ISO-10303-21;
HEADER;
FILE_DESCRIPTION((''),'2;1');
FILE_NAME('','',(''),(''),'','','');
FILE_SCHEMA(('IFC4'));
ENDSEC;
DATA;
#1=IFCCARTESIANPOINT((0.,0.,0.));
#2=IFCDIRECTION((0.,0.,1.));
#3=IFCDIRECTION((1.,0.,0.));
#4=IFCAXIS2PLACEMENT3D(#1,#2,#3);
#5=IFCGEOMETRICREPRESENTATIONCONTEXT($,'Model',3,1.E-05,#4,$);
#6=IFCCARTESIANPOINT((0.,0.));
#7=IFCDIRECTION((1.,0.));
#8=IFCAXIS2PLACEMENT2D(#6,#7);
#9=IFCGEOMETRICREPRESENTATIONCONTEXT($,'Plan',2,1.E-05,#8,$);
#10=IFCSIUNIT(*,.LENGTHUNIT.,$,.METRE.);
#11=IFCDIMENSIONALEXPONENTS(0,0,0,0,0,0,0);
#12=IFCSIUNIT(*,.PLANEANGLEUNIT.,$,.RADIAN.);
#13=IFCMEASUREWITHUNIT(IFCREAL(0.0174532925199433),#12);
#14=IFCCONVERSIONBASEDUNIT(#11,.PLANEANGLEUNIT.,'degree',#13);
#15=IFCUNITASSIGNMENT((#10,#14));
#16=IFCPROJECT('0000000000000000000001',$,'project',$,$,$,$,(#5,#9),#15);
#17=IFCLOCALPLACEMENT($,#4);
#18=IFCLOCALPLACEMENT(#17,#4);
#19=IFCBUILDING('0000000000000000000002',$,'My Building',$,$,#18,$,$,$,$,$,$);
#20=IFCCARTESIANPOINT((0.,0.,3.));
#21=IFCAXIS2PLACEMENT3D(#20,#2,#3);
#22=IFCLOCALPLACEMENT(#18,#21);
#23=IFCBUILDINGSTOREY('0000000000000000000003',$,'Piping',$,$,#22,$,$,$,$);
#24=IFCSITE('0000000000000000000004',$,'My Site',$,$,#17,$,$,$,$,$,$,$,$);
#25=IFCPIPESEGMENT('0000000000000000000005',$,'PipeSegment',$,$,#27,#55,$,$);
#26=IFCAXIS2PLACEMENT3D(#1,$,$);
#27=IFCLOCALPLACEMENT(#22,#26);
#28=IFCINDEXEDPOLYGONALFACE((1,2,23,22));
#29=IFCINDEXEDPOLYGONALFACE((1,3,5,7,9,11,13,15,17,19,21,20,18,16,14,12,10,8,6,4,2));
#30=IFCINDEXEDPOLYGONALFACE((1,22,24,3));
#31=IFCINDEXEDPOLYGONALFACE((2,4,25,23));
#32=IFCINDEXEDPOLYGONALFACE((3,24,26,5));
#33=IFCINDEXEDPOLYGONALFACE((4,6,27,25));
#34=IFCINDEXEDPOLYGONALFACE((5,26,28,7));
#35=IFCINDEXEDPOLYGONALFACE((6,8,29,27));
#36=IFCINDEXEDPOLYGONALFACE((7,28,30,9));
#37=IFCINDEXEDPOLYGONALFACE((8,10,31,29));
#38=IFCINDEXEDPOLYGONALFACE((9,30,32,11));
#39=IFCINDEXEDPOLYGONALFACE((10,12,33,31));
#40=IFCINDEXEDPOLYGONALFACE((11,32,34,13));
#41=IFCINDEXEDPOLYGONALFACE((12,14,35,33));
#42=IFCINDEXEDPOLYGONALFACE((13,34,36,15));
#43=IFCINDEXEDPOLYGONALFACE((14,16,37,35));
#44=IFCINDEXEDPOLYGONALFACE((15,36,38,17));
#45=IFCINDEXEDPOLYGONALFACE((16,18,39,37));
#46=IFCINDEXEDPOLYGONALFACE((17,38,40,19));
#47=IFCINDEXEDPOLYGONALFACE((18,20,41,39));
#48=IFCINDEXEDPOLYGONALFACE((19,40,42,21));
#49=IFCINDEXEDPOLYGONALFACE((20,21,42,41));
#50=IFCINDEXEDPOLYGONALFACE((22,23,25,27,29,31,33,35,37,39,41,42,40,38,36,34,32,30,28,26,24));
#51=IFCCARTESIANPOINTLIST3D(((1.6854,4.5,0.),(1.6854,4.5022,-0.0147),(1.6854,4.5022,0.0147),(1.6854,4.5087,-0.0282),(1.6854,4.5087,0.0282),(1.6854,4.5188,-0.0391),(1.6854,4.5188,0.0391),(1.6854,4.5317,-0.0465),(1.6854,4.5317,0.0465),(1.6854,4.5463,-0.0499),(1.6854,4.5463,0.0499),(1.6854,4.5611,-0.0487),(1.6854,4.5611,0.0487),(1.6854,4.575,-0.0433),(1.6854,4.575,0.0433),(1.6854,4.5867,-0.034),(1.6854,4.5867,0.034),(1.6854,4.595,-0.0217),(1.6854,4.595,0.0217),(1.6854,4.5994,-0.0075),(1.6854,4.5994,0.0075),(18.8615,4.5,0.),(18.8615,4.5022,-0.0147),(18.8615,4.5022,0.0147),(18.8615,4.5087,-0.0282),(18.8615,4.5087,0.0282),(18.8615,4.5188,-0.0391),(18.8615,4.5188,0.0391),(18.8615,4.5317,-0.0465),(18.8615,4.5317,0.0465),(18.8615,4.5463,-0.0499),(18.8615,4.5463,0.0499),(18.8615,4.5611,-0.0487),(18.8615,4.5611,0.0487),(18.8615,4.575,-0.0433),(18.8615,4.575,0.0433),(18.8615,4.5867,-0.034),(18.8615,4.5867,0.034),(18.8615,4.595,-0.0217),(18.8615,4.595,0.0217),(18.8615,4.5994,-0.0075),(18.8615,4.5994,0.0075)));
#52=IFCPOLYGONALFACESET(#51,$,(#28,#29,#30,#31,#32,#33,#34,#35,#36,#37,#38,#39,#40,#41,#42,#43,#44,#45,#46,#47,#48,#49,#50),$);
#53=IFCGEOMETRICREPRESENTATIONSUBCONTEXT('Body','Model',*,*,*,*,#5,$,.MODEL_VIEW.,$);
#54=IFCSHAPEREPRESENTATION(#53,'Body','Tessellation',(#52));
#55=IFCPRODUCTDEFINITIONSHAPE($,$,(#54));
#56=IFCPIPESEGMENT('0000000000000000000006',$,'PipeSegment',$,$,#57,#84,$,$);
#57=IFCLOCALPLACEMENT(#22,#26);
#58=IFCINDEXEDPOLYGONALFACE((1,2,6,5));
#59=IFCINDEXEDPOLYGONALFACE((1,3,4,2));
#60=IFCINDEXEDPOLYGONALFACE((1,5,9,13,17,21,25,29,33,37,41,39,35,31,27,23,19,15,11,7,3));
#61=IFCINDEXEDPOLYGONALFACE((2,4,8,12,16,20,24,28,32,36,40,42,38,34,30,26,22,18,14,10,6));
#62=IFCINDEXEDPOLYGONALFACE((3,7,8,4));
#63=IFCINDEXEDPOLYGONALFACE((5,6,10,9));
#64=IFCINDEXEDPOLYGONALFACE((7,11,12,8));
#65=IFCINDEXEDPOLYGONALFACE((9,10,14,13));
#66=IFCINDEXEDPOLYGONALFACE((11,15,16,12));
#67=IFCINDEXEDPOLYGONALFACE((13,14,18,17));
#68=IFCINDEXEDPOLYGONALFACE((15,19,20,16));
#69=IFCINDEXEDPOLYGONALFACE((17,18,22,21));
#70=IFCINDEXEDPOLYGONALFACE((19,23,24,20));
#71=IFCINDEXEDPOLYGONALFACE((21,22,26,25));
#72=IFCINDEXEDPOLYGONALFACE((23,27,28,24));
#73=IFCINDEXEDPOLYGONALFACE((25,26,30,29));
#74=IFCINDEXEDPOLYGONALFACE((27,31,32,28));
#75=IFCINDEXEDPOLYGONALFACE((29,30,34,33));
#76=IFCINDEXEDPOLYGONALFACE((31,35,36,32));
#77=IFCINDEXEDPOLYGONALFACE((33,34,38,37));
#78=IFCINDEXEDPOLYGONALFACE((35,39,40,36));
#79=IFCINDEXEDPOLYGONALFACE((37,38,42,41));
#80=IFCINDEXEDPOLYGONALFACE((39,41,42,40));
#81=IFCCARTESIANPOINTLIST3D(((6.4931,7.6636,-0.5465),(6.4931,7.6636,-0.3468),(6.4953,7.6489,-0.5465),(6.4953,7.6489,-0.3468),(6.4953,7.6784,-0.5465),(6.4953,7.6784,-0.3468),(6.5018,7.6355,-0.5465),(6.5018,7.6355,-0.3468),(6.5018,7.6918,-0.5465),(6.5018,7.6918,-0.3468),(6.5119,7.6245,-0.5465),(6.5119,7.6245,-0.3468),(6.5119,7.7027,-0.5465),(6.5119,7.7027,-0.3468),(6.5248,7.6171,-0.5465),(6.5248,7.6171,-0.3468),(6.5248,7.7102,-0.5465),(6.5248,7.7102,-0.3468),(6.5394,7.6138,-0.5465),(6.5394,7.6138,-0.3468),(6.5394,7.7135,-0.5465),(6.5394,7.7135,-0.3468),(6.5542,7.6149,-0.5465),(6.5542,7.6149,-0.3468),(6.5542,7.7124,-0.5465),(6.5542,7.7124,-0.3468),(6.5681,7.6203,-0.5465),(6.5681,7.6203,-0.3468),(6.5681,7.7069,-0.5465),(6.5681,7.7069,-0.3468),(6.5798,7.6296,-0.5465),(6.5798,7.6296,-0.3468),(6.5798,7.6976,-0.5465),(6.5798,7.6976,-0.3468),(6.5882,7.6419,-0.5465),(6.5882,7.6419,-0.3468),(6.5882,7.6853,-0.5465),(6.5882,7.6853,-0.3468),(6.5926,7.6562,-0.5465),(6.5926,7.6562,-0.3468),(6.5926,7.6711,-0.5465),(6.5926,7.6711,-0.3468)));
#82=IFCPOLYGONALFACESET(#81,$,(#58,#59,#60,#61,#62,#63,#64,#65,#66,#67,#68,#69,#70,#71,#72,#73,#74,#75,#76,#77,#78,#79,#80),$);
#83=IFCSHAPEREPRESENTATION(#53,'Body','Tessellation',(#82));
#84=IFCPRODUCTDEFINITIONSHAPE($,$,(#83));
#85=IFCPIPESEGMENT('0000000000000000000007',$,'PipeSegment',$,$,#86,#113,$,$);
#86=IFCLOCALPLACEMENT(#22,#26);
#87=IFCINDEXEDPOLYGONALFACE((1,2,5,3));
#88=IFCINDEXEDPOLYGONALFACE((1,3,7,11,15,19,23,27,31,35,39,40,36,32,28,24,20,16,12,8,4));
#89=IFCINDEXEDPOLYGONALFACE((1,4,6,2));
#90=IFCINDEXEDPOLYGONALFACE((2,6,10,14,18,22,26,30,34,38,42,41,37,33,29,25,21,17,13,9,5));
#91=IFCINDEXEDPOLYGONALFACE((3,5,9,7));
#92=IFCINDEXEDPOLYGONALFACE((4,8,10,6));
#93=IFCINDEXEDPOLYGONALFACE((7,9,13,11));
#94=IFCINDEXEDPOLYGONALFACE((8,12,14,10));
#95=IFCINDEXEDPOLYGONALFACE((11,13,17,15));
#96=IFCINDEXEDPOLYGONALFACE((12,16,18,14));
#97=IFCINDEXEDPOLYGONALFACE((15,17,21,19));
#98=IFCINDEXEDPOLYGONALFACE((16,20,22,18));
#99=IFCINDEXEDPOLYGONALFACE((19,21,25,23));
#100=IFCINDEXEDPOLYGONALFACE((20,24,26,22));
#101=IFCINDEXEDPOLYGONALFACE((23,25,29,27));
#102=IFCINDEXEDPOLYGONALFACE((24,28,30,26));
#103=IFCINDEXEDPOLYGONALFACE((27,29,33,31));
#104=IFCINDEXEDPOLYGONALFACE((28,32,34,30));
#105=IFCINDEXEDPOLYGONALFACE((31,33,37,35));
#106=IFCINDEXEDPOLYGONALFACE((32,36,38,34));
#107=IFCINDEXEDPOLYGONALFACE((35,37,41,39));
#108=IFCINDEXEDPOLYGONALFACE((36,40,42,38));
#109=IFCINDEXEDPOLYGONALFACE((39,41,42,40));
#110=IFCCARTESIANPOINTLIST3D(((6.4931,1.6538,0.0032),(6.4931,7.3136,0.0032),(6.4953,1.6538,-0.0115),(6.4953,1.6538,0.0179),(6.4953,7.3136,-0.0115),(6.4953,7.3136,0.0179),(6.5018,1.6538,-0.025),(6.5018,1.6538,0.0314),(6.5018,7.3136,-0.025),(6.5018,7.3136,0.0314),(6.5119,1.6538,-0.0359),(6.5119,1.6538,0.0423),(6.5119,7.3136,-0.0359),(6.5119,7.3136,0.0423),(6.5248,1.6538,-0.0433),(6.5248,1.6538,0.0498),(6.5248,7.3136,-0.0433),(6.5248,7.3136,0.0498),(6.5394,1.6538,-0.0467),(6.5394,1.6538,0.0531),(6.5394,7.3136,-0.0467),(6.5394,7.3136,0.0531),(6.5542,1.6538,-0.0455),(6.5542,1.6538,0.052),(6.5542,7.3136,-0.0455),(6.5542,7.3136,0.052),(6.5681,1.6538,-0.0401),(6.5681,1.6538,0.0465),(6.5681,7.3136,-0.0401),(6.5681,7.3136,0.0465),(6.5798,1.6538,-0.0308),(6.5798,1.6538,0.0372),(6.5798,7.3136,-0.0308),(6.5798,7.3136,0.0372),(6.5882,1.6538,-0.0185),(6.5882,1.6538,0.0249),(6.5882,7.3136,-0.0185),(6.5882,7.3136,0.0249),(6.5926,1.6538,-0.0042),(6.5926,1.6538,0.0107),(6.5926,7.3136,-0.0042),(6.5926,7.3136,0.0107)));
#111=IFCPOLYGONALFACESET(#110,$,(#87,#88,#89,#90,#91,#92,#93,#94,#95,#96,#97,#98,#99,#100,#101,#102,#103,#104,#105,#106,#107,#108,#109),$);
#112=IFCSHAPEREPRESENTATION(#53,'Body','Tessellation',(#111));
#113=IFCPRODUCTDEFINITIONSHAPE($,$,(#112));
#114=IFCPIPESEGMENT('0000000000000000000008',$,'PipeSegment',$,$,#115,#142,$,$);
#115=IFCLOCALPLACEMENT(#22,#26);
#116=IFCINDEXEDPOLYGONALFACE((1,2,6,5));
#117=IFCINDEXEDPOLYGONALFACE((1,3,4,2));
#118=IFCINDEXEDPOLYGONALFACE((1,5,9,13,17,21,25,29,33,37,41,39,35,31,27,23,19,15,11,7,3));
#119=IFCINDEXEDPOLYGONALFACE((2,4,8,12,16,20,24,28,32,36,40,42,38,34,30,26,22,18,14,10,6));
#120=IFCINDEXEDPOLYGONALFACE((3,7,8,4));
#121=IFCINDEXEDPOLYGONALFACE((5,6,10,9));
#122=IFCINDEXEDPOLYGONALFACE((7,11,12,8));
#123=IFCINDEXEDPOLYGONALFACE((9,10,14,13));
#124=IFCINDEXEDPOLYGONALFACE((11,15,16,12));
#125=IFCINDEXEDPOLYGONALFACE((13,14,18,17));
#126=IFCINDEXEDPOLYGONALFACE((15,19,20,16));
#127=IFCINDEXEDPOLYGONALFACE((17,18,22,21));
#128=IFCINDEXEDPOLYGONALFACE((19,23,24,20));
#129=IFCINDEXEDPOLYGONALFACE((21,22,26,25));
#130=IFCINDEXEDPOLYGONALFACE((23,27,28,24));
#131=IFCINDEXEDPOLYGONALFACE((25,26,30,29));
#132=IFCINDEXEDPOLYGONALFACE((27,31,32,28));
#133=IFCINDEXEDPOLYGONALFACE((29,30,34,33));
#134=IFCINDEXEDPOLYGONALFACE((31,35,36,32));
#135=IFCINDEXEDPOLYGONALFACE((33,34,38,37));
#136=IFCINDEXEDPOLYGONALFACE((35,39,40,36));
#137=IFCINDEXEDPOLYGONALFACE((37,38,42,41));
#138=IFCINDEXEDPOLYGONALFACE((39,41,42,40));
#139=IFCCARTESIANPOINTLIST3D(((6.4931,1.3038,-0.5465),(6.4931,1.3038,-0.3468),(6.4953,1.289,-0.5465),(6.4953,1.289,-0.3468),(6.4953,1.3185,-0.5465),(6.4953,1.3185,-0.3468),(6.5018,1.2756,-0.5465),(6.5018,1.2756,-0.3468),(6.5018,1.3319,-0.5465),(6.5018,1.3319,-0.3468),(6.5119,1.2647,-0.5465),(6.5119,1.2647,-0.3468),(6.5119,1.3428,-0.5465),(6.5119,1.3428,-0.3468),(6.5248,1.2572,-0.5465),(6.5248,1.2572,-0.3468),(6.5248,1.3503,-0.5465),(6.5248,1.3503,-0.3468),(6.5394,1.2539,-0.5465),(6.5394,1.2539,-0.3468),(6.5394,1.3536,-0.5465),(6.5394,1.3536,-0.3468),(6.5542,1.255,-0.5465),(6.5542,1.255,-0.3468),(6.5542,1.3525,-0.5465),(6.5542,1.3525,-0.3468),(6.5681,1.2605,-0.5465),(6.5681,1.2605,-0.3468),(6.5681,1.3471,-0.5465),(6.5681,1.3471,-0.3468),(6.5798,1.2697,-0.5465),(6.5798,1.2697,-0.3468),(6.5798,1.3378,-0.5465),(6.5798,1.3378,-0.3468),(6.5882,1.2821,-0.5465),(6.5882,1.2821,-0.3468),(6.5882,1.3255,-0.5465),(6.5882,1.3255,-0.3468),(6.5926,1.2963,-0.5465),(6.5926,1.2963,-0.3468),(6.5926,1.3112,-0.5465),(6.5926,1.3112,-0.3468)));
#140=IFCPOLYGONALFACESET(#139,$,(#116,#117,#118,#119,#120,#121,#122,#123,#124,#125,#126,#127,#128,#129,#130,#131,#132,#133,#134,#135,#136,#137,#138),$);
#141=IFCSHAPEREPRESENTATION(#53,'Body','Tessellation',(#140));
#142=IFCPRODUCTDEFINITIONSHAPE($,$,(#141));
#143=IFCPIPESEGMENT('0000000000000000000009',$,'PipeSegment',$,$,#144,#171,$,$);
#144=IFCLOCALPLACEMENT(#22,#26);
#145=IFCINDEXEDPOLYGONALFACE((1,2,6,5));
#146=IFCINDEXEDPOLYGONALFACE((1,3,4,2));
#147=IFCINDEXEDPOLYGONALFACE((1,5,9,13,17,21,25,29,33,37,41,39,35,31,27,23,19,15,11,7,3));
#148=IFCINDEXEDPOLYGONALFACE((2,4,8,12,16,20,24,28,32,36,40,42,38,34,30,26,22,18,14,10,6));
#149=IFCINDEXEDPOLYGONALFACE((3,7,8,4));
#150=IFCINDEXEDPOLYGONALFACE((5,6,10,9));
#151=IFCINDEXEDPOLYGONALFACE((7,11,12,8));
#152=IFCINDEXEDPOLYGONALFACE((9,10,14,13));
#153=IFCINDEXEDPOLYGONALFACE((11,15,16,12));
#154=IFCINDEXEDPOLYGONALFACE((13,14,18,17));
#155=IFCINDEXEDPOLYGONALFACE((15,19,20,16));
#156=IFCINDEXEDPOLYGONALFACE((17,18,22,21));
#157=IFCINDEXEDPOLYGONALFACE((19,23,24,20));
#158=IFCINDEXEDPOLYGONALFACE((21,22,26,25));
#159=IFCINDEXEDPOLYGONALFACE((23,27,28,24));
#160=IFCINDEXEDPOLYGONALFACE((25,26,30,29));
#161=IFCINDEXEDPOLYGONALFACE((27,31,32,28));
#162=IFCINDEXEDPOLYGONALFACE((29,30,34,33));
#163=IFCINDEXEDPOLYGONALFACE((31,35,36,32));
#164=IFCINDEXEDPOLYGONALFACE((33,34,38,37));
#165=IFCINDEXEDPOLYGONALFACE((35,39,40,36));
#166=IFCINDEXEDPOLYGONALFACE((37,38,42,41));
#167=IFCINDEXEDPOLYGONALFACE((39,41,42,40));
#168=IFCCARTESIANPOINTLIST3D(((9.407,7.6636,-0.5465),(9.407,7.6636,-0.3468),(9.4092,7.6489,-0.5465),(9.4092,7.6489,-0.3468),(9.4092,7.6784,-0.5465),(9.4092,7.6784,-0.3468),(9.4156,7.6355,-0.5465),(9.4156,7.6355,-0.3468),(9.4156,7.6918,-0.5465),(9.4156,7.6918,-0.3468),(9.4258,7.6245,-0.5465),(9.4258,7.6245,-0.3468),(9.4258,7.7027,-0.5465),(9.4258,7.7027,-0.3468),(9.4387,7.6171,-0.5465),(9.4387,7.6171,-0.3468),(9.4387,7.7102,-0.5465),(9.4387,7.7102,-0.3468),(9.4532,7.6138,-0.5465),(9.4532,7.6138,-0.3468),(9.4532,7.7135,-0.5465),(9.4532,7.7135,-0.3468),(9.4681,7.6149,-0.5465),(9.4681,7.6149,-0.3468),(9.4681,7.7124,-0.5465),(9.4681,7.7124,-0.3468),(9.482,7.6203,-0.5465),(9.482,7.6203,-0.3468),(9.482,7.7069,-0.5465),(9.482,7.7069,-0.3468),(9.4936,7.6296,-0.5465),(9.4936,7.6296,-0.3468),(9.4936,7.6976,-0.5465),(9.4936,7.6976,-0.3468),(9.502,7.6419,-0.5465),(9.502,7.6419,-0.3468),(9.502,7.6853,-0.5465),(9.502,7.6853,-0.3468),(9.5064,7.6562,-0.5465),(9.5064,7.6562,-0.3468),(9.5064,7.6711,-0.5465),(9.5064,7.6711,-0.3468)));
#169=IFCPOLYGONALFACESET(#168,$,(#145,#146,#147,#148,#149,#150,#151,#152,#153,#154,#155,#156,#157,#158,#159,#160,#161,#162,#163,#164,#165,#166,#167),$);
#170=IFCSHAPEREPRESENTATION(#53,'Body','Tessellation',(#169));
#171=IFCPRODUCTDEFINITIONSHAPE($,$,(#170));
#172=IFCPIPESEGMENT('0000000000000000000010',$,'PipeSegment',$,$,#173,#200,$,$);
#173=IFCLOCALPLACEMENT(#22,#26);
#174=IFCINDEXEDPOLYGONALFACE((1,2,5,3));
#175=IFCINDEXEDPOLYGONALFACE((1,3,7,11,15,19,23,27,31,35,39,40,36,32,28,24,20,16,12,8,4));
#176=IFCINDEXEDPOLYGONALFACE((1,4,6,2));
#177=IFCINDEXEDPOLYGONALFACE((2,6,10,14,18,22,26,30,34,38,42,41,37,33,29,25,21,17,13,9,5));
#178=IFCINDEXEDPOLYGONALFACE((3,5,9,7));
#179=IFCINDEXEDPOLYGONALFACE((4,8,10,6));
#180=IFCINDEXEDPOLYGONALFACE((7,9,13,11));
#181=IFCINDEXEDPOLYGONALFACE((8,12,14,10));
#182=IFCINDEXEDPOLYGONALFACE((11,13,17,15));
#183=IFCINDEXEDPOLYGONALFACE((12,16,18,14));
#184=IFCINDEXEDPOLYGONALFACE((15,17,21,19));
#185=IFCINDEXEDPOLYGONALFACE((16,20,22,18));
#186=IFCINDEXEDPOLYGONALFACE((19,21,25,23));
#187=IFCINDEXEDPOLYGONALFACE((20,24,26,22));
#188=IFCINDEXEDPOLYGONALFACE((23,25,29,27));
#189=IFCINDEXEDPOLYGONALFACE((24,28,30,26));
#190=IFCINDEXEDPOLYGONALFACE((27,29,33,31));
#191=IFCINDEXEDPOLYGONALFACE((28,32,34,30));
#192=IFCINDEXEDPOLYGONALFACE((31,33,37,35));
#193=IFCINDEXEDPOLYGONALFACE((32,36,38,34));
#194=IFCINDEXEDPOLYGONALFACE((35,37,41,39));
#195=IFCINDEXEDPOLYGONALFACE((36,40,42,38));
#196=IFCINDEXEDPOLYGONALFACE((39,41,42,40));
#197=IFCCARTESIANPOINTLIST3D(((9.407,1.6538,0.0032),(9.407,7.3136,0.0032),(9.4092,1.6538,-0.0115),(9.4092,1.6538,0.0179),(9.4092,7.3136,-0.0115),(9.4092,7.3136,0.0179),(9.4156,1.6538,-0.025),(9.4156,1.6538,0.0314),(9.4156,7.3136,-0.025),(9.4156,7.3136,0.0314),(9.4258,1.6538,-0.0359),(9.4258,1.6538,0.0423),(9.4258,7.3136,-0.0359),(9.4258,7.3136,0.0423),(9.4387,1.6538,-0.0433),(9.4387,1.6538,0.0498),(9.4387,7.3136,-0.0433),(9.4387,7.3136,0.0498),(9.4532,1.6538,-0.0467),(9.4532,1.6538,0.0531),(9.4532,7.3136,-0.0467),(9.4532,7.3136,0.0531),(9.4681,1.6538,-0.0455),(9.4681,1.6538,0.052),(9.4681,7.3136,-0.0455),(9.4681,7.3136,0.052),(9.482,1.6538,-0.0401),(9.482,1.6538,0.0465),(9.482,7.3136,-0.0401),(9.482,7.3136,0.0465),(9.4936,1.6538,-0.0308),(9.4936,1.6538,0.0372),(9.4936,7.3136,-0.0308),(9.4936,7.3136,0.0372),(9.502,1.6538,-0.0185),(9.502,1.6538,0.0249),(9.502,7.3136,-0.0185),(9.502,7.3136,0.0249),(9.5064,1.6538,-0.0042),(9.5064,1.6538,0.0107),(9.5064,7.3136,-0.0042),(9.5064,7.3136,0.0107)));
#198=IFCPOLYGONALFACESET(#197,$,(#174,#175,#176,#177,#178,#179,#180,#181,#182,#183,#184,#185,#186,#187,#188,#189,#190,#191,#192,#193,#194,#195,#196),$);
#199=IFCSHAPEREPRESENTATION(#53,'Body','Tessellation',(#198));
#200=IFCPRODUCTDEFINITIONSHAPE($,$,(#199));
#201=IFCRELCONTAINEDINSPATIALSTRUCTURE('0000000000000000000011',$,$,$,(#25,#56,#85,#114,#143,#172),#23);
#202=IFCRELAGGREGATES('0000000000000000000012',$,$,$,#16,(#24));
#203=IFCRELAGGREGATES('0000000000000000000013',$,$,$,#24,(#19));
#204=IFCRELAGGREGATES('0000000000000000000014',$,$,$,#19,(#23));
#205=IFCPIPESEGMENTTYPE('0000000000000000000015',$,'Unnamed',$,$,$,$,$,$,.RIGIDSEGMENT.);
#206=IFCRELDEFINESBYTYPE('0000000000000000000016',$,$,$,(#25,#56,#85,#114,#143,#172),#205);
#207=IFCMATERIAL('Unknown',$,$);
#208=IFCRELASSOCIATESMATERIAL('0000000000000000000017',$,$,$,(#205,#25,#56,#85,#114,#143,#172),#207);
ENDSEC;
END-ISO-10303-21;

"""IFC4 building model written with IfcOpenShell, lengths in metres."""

from ifc_helpers import new_model, entity, si_unit, converted_unit, frame, origin_with_axes, origin_2d_with_axis, place, context, subcontext, project, spatial, circle, extrude, material, material_profile, profile_set, profile_usage, type_object, element, save


model = new_model("IFC4")

# Units and contexts
model_context = context("Model", 3, precision=1e-05, world=origin_with_axes())
plan_context = context("Plan", 2, precision=1e-05, world=origin_2d_with_axis())
body_context = subcontext(model_context, "Body", "Model", "MODEL_VIEW")
ifc_project = project(units=[si_unit("LENGTHUNIT", "METRE"), converted_unit("PLANEANGLEUNIT", "degree", entity("IfcReal", 0.0174532925199433), si_unit("PLANEANGLEUNIT", "RADIAN"), dimensions=[0, 0, 0, 0, 0, 0, 0])], contexts=[model_context, plan_context])

# Site, building, storey
site_placement = place(None, origin_with_axes())
site = spatial("IfcSite", under=ifc_project, at=site_placement, Name="My Site")
building_placement = place(site_placement, origin_with_axes())
building = spatial("IfcBuilding", under=site, at=building_placement, Name="My Building")
storey_placement = place(building_placement, frame((0.0, 0.0, 3.0), z_axis=(0.0, 0.0, 1.0), x_axis=(1.0, 0.0, 0.0)))
storey = spatial("IfcBuildingStorey", under=building, at=storey_placement, Name="Piping")

# Pipe segments
ifc_material = material(Name="Unknown")
ifc_material_profile = material_profile(ifc_material, circle(Radius=0.05))
ifc_profile_set = profile_set([ifc_material_profile])
ifc_profile_usage_1 = profile_usage(ifc_profile_set, cardinal=5)
pipe_segment_type = type_object("IfcPipeSegmentType", Name="Unnamed", PredefinedType="RIGIDSEGMENT", material=ifc_profile_set)
pipe_segment_1_placement = place(storey_placement, frame((18.8615, 4.55, 0.0), z_axis=(-1.0, 0.0, 0.0), x_axis=(0.0, -1.0, 0.0)))
element("IfcPipeSegment", 1, at=pipe_segment_1_placement, inside=storey, type_object=pipe_segment_type, material=ifc_profile_usage_1, Name="PipeSegment", context=body_context, shape_type="SweptSolid", body=[
    extrude(circle(Radius=0.05), origin_with_axes(), (0.0, 0.0, 1.0), 17.1761),
])
ifc_profile_usage_2 = profile_usage(ifc_profile_set, cardinal=5)
pipe_segment_2_placement = place(storey_placement, frame((6.5431, 7.6636, -0.3468), z_axis=(0.0, 0.0, -1.0), x_axis=(-1.0, 0.0, 0.0)))
element("IfcPipeSegment", 2, at=pipe_segment_2_placement, inside=storey, type_object=pipe_segment_type, material=ifc_profile_usage_2, Name="PipeSegment", context=body_context, shape_type="SweptSolid", body=[
    extrude(circle(Radius=0.05), origin_with_axes(), (0.0, 0.0, 1.0), 0.1997),
])
ifc_profile_usage_3 = profile_usage(ifc_profile_set, cardinal=5)
pipe_segment_3_placement = place(storey_placement, frame((6.5431, 1.6538, 0.0032), z_axis=(0.0, 1.0, 0.0), x_axis=(-1.0, 0.0, 0.0)))
element("IfcPipeSegment", 3, at=pipe_segment_3_placement, inside=storey, type_object=pipe_segment_type, material=ifc_profile_usage_3, Name="PipeSegment", context=body_context, shape_type="SweptSolid", body=[
    extrude(circle(Radius=0.05), origin_with_axes(), (0.0, 0.0, 1.0), 5.6599),
])
ifc_profile_usage_4 = profile_usage(ifc_profile_set, cardinal=5)
pipe_segment_4_placement = place(storey_placement, frame((6.5431, 1.3038, -0.3468), z_axis=(0.0, 0.0, -1.0), x_axis=(-1.0, 0.0, 0.0)))
element("IfcPipeSegment", 4, at=pipe_segment_4_placement, inside=storey, type_object=pipe_segment_type, material=ifc_profile_usage_4, Name="PipeSegment", context=body_context, shape_type="SweptSolid", body=[
    extrude(circle(Radius=0.05), origin_with_axes(), (0.0, 0.0, 1.0), 0.1997),
])
ifc_profile_usage_5 = profile_usage(ifc_profile_set, cardinal=5)
pipe_segment_5_placement = place(storey_placement, frame((9.457, 7.6636, -0.3468), z_axis=(0.0, 0.0, -1.0), x_axis=(-1.0, 0.0, 0.0)))
element("IfcPipeSegment", 5, at=pipe_segment_5_placement, inside=storey, type_object=pipe_segment_type, material=ifc_profile_usage_5, Name="PipeSegment", context=body_context, shape_type="SweptSolid", body=[
    extrude(circle(Radius=0.05), origin_with_axes(), (0.0, 0.0, 1.0), 0.1997),
])
ifc_profile_usage_6 = profile_usage(ifc_profile_set, cardinal=5)
pipe_segment_6_placement = place(storey_placement, frame((9.457, 1.6538, 0.0032), z_axis=(0.0, 1.0, 0.0), x_axis=(-1.0, 0.0, 0.0)))
element("IfcPipeSegment", 6, at=pipe_segment_6_placement, inside=storey, type_object=pipe_segment_type, material=ifc_profile_usage_6, Name="PipeSegment", context=body_context, shape_type="SweptSolid", body=[
    extrude(circle(Radius=0.05), origin_with_axes(), (0.0, 0.0, 1.0), 5.6599),
])

save(model, "model.ifc")
